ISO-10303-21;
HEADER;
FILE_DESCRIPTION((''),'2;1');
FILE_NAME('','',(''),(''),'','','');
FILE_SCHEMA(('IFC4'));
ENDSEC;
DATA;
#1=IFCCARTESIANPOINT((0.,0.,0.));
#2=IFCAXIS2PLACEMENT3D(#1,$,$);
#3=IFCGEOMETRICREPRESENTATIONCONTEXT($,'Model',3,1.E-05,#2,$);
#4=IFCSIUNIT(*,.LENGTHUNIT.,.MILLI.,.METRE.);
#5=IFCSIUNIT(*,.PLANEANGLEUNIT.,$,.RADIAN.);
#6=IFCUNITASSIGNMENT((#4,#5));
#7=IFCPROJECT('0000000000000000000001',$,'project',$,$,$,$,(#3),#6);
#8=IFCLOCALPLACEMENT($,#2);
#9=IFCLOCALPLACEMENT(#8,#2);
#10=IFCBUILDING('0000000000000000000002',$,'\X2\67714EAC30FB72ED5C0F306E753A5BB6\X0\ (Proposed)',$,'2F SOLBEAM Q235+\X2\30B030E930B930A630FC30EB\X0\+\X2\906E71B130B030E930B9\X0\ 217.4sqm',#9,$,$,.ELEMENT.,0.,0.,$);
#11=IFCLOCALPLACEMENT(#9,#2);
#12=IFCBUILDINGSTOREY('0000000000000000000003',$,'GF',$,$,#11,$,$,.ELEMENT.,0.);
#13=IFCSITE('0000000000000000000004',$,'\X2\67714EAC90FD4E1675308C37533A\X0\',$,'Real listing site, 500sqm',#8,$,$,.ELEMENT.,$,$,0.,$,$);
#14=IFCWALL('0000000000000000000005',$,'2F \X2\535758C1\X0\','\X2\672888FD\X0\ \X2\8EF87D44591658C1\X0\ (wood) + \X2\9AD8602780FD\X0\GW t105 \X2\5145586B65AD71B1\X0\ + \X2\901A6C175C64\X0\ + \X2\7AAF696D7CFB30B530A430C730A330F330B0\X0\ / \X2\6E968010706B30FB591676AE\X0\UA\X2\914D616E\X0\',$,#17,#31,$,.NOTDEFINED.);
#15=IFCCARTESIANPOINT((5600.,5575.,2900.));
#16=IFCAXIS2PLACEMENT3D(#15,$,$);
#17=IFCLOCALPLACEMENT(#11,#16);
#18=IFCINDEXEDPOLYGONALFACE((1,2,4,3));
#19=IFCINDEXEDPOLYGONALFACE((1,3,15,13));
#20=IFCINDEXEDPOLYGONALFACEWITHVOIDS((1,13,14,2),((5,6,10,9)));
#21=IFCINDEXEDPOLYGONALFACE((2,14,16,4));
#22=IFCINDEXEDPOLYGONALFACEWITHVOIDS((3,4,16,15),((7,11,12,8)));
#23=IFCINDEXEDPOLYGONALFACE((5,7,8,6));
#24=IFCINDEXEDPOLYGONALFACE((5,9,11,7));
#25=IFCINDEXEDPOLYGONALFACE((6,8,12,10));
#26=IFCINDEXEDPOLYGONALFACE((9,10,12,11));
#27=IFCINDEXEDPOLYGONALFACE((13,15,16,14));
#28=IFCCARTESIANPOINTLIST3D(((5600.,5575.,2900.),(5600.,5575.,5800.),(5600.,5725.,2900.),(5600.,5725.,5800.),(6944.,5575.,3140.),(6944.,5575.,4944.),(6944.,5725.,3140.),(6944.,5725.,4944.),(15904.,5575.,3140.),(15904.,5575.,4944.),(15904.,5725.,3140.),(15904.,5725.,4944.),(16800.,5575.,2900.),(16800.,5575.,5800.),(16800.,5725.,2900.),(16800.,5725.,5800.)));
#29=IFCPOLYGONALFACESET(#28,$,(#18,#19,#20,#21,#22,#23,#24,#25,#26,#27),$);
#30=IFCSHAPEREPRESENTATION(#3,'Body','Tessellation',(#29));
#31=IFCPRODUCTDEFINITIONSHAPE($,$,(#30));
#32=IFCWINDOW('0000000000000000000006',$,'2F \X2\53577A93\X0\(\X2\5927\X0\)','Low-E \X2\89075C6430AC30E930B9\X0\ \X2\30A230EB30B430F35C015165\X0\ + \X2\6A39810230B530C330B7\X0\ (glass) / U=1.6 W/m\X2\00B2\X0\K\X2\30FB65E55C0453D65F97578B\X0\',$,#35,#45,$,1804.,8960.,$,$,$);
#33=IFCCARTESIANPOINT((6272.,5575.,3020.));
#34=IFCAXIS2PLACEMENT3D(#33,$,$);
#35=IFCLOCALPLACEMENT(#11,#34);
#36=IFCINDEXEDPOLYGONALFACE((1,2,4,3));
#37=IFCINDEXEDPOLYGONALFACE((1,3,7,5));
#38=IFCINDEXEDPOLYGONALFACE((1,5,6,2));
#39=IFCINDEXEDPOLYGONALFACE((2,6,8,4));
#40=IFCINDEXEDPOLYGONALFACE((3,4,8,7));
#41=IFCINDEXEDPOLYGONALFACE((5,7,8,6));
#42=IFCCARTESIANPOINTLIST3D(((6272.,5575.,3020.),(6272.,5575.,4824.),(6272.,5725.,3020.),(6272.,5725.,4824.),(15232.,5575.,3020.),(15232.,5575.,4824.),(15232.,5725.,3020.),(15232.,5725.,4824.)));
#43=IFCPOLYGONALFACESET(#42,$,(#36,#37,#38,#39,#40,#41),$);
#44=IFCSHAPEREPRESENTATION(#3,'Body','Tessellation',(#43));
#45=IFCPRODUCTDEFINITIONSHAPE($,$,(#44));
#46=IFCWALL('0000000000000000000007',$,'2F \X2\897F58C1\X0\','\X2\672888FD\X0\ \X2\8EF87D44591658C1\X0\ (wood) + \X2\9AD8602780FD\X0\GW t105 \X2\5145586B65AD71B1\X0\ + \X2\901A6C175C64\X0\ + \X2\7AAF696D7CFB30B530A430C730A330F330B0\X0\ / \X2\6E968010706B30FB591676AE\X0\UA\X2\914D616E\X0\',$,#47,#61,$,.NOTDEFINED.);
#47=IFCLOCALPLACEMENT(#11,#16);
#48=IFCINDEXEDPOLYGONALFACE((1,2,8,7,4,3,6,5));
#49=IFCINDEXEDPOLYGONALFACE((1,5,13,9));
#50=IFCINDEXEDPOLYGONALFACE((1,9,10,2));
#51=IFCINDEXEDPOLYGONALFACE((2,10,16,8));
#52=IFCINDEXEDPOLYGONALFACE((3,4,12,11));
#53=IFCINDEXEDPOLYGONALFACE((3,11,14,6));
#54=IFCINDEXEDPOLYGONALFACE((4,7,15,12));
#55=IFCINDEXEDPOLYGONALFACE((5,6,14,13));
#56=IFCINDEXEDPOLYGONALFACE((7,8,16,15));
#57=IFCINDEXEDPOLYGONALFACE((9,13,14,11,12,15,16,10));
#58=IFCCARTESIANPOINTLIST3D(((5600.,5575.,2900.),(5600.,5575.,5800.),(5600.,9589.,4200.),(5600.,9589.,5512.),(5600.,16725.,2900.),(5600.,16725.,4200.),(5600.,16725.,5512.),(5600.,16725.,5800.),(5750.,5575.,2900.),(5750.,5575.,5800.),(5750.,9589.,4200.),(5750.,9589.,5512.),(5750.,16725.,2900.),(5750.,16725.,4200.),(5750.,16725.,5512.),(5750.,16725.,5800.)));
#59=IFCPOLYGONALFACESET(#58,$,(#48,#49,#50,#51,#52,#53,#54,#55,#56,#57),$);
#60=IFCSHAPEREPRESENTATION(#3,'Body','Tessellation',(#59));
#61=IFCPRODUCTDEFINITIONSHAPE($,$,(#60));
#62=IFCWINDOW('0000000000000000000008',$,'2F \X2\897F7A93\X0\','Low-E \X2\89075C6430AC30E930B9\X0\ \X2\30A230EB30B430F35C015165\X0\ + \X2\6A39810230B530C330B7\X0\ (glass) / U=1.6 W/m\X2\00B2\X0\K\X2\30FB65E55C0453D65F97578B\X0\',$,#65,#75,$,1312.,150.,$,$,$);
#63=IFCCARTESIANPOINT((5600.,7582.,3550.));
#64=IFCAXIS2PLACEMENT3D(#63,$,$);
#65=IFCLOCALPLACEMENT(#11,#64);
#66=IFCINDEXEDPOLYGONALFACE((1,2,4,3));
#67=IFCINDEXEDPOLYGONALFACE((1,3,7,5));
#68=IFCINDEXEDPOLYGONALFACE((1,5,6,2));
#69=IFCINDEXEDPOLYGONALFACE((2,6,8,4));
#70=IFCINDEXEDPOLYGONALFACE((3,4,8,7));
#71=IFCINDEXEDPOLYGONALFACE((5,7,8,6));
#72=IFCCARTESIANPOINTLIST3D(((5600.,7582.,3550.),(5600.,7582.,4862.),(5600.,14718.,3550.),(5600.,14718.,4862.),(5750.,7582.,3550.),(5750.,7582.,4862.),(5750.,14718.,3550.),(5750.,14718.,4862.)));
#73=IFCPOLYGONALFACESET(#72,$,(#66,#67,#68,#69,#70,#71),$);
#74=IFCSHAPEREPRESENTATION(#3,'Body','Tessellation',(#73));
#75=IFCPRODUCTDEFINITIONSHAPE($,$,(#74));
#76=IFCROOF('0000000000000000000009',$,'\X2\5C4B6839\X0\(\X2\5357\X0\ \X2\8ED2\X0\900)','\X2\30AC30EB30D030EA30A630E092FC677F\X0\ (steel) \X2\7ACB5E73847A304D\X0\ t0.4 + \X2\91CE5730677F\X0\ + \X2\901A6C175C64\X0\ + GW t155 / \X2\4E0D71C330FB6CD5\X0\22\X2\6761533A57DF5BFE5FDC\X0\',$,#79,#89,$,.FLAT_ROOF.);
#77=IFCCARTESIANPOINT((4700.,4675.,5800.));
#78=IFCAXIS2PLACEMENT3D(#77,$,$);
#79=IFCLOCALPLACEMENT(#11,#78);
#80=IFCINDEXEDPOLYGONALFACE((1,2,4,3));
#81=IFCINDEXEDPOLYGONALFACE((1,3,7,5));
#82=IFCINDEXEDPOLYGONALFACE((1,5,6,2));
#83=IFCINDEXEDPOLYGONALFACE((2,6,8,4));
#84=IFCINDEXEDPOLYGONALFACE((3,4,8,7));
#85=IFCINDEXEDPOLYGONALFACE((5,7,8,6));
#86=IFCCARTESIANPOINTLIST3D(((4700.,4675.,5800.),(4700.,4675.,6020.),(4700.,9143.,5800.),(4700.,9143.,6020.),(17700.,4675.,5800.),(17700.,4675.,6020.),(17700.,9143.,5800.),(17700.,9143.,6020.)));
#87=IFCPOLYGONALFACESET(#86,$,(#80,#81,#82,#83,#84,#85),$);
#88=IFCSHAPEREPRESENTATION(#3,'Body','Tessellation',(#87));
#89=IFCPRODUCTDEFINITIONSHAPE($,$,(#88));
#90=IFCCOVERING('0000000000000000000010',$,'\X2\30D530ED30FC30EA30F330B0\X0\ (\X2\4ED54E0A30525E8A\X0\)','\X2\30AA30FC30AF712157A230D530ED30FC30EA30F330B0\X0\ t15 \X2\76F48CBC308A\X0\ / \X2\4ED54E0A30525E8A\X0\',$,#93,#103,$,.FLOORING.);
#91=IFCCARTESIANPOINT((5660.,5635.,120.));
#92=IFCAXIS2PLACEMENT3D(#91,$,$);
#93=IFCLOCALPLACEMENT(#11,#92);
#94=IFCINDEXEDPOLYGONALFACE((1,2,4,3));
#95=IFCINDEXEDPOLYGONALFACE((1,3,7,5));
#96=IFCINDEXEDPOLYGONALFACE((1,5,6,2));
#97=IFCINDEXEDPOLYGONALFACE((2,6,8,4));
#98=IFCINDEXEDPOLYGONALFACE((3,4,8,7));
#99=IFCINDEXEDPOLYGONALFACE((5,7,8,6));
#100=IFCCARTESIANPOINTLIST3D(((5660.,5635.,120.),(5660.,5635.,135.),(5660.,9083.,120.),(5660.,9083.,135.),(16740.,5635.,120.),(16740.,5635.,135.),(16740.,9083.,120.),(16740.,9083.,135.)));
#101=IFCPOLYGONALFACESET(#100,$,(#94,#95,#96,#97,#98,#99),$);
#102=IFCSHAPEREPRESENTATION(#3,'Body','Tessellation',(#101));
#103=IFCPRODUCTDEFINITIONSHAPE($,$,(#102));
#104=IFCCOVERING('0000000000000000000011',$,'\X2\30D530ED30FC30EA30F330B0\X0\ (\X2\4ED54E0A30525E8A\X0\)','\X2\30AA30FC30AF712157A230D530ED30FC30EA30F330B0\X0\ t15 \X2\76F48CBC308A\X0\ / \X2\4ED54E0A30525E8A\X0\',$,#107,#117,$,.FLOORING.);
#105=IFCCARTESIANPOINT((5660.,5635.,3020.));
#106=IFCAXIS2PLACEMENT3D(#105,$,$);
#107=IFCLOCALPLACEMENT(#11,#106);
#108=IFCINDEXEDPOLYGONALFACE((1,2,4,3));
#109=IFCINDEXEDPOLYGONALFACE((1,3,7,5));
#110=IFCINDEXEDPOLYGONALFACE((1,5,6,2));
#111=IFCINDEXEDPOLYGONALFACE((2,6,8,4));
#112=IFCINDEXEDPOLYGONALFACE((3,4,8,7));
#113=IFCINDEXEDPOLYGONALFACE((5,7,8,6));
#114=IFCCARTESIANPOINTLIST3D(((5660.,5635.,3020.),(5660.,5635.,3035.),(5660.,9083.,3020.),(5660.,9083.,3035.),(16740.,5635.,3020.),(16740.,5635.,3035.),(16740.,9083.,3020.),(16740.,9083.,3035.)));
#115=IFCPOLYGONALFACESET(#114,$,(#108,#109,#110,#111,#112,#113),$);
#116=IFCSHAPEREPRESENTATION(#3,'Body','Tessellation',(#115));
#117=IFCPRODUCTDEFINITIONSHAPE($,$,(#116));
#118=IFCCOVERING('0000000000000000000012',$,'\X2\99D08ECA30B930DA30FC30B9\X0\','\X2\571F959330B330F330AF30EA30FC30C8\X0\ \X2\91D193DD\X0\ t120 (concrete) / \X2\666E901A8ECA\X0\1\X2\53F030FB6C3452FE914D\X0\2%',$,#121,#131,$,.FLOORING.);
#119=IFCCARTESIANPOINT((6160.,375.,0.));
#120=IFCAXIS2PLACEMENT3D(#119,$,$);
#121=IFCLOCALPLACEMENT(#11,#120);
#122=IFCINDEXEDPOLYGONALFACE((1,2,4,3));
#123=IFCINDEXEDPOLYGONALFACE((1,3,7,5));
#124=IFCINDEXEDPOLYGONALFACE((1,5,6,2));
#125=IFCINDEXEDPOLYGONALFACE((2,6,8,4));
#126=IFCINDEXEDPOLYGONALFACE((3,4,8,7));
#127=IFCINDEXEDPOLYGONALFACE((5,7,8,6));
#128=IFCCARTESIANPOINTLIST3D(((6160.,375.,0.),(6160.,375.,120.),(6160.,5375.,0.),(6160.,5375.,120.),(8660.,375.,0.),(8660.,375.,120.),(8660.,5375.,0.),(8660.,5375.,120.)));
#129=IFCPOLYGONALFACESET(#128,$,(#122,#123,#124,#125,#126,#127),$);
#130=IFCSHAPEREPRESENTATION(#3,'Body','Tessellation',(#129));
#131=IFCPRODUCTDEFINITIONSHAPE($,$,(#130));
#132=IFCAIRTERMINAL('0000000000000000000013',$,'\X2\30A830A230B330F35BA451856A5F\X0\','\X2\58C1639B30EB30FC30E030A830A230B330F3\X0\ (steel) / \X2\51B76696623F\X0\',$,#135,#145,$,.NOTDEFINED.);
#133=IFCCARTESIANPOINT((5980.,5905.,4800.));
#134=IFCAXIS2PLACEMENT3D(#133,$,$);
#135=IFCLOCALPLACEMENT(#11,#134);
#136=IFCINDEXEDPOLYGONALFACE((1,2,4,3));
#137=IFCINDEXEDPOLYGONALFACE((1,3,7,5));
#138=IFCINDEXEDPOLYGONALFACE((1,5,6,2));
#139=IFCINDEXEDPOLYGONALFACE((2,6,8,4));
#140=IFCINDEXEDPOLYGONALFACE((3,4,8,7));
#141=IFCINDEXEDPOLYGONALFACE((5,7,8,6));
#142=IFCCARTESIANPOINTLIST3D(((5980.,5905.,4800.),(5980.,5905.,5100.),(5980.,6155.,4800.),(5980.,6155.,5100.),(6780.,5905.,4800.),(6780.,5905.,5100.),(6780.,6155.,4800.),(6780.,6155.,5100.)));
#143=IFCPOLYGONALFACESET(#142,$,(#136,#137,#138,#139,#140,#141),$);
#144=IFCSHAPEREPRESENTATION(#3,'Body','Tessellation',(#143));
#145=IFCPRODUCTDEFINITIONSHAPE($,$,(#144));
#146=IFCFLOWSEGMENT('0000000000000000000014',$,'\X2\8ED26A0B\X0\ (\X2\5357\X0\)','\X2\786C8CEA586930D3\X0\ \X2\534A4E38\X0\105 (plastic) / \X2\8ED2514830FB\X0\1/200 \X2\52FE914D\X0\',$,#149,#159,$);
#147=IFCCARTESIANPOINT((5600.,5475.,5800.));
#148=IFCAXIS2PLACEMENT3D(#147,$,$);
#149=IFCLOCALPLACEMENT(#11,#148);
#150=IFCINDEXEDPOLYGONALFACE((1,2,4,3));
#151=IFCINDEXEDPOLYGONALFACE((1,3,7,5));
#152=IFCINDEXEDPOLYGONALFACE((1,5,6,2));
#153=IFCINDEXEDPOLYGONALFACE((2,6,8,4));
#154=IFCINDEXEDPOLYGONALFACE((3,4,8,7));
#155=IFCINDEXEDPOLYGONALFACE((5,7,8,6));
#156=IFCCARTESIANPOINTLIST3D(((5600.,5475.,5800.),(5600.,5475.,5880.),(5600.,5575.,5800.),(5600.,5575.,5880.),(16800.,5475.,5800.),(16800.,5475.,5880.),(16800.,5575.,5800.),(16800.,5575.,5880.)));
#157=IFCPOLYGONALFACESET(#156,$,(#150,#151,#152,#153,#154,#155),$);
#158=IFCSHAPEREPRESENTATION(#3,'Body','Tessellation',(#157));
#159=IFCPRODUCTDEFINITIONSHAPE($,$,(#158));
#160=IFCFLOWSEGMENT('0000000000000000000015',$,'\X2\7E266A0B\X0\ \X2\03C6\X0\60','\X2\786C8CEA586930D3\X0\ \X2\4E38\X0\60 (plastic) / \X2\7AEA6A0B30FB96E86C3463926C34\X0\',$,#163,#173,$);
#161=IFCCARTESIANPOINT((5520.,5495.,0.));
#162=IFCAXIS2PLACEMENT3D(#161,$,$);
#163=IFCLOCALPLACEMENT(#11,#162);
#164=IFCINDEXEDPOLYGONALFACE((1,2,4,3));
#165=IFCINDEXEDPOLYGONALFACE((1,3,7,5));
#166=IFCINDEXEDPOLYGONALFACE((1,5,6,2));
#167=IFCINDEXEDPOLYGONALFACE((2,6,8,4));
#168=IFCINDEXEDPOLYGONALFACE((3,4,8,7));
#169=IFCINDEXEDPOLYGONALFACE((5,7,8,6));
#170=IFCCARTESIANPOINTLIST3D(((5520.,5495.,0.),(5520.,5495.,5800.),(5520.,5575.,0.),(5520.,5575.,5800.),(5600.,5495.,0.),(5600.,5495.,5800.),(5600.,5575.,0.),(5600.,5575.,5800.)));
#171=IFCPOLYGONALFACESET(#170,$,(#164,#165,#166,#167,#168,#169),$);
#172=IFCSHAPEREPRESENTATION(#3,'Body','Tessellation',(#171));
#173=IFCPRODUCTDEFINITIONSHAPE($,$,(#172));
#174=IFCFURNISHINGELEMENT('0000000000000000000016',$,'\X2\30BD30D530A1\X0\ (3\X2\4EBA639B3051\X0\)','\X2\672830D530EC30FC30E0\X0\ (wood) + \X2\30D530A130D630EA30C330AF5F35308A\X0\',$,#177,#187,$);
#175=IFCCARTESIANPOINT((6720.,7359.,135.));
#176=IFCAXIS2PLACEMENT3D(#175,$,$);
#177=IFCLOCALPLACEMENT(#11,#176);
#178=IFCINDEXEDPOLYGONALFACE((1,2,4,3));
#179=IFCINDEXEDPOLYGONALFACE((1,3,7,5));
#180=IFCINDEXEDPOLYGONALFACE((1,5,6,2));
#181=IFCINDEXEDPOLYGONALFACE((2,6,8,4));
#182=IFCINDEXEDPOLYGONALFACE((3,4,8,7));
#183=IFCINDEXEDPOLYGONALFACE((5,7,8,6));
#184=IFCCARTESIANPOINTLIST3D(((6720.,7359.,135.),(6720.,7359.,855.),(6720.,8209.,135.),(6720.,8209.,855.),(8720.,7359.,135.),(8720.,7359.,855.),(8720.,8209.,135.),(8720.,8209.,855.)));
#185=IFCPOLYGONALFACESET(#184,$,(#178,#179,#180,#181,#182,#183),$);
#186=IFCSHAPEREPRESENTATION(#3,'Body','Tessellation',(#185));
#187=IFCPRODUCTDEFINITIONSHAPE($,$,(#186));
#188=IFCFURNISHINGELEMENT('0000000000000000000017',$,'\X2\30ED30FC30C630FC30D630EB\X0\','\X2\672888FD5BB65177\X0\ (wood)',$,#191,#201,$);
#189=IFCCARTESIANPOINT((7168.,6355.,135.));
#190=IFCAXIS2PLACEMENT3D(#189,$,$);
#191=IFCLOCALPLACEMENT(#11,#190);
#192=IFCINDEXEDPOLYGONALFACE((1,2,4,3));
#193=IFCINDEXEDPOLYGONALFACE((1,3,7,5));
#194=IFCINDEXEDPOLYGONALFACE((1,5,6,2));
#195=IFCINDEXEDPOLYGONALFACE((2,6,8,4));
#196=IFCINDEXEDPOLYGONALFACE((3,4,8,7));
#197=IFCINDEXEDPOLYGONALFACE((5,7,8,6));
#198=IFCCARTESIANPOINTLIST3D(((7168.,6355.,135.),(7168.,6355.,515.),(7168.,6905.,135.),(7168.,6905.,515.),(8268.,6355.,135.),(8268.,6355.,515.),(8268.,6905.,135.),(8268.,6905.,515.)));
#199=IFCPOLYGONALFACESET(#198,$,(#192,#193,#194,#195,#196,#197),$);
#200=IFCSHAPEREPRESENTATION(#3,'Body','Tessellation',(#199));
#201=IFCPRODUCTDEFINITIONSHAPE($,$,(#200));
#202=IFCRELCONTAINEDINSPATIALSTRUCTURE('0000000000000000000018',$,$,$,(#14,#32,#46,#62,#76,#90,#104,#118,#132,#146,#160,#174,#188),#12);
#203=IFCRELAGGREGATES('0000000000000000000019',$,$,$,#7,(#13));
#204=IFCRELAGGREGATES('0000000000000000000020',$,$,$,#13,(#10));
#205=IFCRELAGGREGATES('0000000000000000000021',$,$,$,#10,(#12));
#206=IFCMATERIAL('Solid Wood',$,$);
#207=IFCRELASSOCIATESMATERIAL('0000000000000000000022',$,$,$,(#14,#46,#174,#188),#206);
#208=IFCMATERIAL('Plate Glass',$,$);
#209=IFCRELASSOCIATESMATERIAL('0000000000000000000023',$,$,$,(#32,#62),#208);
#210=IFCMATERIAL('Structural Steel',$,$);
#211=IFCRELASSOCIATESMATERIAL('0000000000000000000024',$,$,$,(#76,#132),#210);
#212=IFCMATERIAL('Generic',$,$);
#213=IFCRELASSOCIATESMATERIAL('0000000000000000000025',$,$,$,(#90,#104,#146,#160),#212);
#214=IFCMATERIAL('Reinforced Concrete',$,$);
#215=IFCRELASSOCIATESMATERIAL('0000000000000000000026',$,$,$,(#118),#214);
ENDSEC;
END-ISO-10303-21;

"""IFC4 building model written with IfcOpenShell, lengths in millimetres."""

from ifc_helpers import new_model, si_unit, frame, frame_2d, origin, place, context, project, spatial, rectangle, extrude, material, element, fill, save


model = new_model("IFC4")

# Units and contexts
model_context = context("Model", 3, precision=1e-05, world=origin())
ifc_project = project(units=[si_unit("LENGTHUNIT", "METRE", prefix="MILLI"), si_unit("PLANEANGLEUNIT", "RADIAN")], contexts=[model_context])

# Site, building, storey
site_placement = place(None, origin())
site = spatial("IfcSite", under=ifc_project, at=site_placement, Name="東京都世田谷区", ObjectType="Real listing site, 500sqm", CompositionType="ELEMENT", RefElevation=0.0)
building_placement = place(site_placement, origin())
building = spatial("IfcBuilding", under=site, at=building_placement, Name="東京・狭小の町家 (Proposed)", ObjectType="2F SOLBEAM Q235+グラスウール+遮熱グラス 217.4sqm", CompositionType="ELEMENT", ElevationOfRefHeight=0.0, ElevationOfTerrain=0.0)
storey_placement = place(building_placement, origin())
storey = spatial("IfcBuildingStorey", under=building, at=storey_placement, Name="GF", CompositionType="ELEMENT", Elevation=0.0)

# Shared definitions
ifc_material_1 = material(Name="Solid Wood")

# Shared definitions
ifc_material_2 = material(Name="Reinforced Concrete")

# Shared definitions
ifc_material_3 = material(Name="Plate Glass")

# Walls, openings, windows
wall_1_placement = place(storey_placement, frame((5600.0, 5575.0, 2900.0)))
wall_1 = element("IfcWall", 1, at=wall_1_placement, inside=storey, material=ifc_material_1, Name="2F 南壁", Description="木製 軸組外壁 (wood) + 高性能GW t105 充填断熱 + 通気層 + 窯業系サイディング / 準耐火・外皮UA配慮", PredefinedType="NOTDEFINED", context=model_context, shape_type="SweptSolid", body=[
    extrude(rectangle(XDim=11200.0, YDim=150.0, at=frame_2d((5600.0, 75.0))), frame((5600.0, 5575.0, 2900.0)), (0.0, 0.0, 1.0), 2900.0),
])
opening_1_placement = place(storey_placement, frame((6272.0, 5575.0, 3020.0)))
opening_1 = element("IfcOpeningElement", 2, at=opening_1_placement, cuts=wall_1, PredefinedType="NOTDEFINED", context=model_context, shape_type="SweptSolid", body=[
    extrude(rectangle(XDim=8960.0, YDim=150.0, at=frame_2d((4480.0, 75.0))), frame((6272.0, 5575.0, 3020.0)), (0.0, 0.0, 1.0), 1804.0),
])
window_1_placement = place(storey_placement, frame((6272.0, 5575.0, 3020.0)))
window_1 = element("IfcWindow", 3, at=window_1_placement, inside=storey, material=ifc_material_3, Name="2F 南窓(大)", Description="Low-E 複層ガラス アルゴン封入 + 樹脂サッシ (glass) / U=1.6 W/m²K・日射取得型", OverallHeight=1804.0, OverallWidth=8960.0, context=model_context, shape_type="SweptSolid", body=[
    extrude(rectangle(XDim=8960.0, YDim=150.0, at=frame_2d((4480.0, 75.0))), frame((6272.0, 5575.0, 3020.0)), (0.0, 0.0, 1.0), 1804.0),
])
fill(opening_1, window_1)
wall_2_placement = place(storey_placement, frame((5600.0, 5575.0, 2900.0)))
wall_2 = element("IfcWall", 4, at=wall_2_placement, inside=storey, material=ifc_material_1, Name="2F 西壁", Description="木製 軸組外壁 (wood) + 高性能GW t105 充填断熱 + 通気層 + 窯業系サイディング / 準耐火・外皮UA配慮", PredefinedType="NOTDEFINED", context=model_context, shape_type="SweptSolid", body=[
    extrude(rectangle(XDim=150.0, YDim=11150.0, at=frame_2d((75.0, 5575.0))), frame((5600.0, 5575.0, 2900.0)), (0.0, 0.0, 1.0), 2900.0),
])
opening_2_placement = place(storey_placement, frame((5600.0, 7582.0, 3550.0)))
opening_2 = element("IfcOpeningElement", 5, at=opening_2_placement, cuts=wall_2, PredefinedType="NOTDEFINED", context=model_context, shape_type="SweptSolid", body=[
    extrude(rectangle(XDim=150.0, YDim=7136.0, at=frame_2d((75.0, 3568.0))), frame((5600.0, 7582.0, 3550.0)), (0.0, 0.0, 1.0), 1312.0),
])
window_2_placement = place(storey_placement, frame((5600.0, 7582.0, 3550.0)))
window_2 = element("IfcWindow", 6, at=window_2_placement, inside=storey, material=ifc_material_3, Name="2F 西窓", Description="Low-E 複層ガラス アルゴン封入 + 樹脂サッシ (glass) / U=1.6 W/m²K・日射取得型", OverallHeight=1312.0, OverallWidth=150.0, context=model_context, shape_type="SweptSolid", body=[
    extrude(rectangle(XDim=150.0, YDim=7136.0, at=frame_2d((75.0, 3568.0))), frame((5600.0, 7582.0, 3550.0)), (0.0, 0.0, 1.0), 1312.0),
])
fill(opening_2, window_2)

# Roof
ifc_material_4 = material(Name="Structural Steel")
for number, where, name in (
    (7, (4700.0, 4675.0, 5800.0), "屋根(南 軒900)"),
):
    element("IfcRoof", number, at=place(storey_placement, frame(where)), inside=storey, material=ifc_material_4, Name=name, Description="ガルバリウム鋼板 (steel) 立平葺き t0.4 + 野地板 + 通気層 + GW t155 / 不燃・法22条区域対応", PredefinedType="FLAT_ROOF", context=model_context, shape_type="SweptSolid", body=[
        extrude(rectangle(XDim=13000.0, YDim=4468.0, at=frame_2d((6500.0, 2234.0))), frame((4700.0, 4675.0, 5800.0)), (0.0, 0.0, 1.0), 220.0),
    ])

# Coverings
ifc_material_5 = material(Name="Generic")
covering_1_placement = place(storey_placement, frame((5660.0, 5635.0, 120.0)))
element("IfcCovering", 8, at=covering_1_placement, inside=storey, material=ifc_material_5, Name="フローリング (仕上げ床)", Description="オーク無垢フローリング t15 直貼り / 仕上げ床", PredefinedType="FLOORING", context=model_context, shape_type="SweptSolid", body=[
    extrude(rectangle(XDim=11080.0, YDim=3448.0, at=frame_2d((5540.0, 1724.0))), frame((5660.0, 5635.0, 120.0)), (0.0, 0.0, 1.0), 15.0),
])
covering_2_placement = place(storey_placement, frame((5660.0, 5635.0, 3020.0)))
element("IfcCovering", 9, at=covering_2_placement, inside=storey, material=ifc_material_5, Name="フローリング (仕上げ床)", Description="オーク無垢フローリング t15 直貼り / 仕上げ床", PredefinedType="FLOORING", context=model_context, shape_type="SweptSolid", body=[
    extrude(rectangle(XDim=11080.0, YDim=3448.0, at=frame_2d((5540.0, 1724.0))), frame((5660.0, 5635.0, 3020.0)), (0.0, 0.0, 1.0), 15.0),
])
covering_3_placement = place(storey_placement, frame((6160.0, 375.0, 0.0)))
element("IfcCovering", 10, at=covering_3_placement, inside=storey, material=ifc_material_2, Name="駐車スペース", Description="土間コンクリート 金鏝 t120 (concrete) / 普通車1台・水勾配2%", PredefinedType="FLOORING", context=model_context, shape_type="SweptSolid", body=[
    extrude(rectangle(XDim=2500.0, YDim=5000.0, at=frame_2d((1250.0, 2500.0))), frame((6160.0, 375.0, 0.0)), (0.0, 0.0, 1.0), 120.0),
])

# Air terminal
air_terminal_placement = place(storey_placement, frame((5980.0, 5905.0, 4800.0)))
element("IfcAirTerminal", 11, at=air_terminal_placement, inside=storey, material=ifc_material_4, Name="エアコン室内機", Description="壁掛ルームエアコン (steel) / 冷暖房", PredefinedType="NOTDEFINED", context=model_context, shape_type="SweptSolid", body=[
    extrude(rectangle(XDim=800.0, YDim=250.0, at=frame_2d((400.0, 125.0))), frame((5980.0, 5905.0, 4800.0)), (0.0, 0.0, 1.0), 300.0),
])

# Flow segments
flow_segment_1_placement = place(storey_placement, frame((5600.0, 5475.0, 5800.0)))
element("IfcFlowSegment", 12, at=flow_segment_1_placement, inside=storey, material=ifc_material_5, Name="軒樋 (南)", Description="硬質塩ビ 半丸105 (plastic) / 軒先・1/200 勾配", context=model_context, shape_type="SweptSolid", body=[
    extrude(rectangle(XDim=11200.0, YDim=100.0, at=frame_2d((5600.0, 50.0))), frame((5600.0, 5475.0, 5800.0)), (0.0, 0.0, 1.0), 80.0),
])
flow_segment_2_placement = place(storey_placement, frame((5520.0, 5495.0, 0.0)))
element("IfcFlowSegment", 13, at=flow_segment_2_placement, inside=storey, material=ifc_material_5, Name="縦樋 φ60", Description="硬質塩ビ 丸60 (plastic) / 竪樋・雨水排水", context=model_context, shape_type="SweptSolid", body=[
    extrude(rectangle(XDim=80.0, YDim=80.0, at=frame_2d((40.0, 40.0))), frame((5520.0, 5495.0, 0.0)), (0.0, 0.0, 1.0), 5800.0),
])

# Furnishing elements
furnishing_1_placement = place(storey_placement, frame((6720.0, 7359.0, 135.0)))
element("IfcFurnishingElement", 14, at=furnishing_1_placement, inside=storey, material=ifc_material_1, Name="ソファ (3人掛け)", Description="木フレーム (wood) + ファブリック張り", context=model_context, shape_type="SweptSolid", body=[
    extrude(rectangle(XDim=2000.0, YDim=850.0, at=frame_2d((1000.0, 425.0))), frame((6720.0, 7359.0, 135.0)), (0.0, 0.0, 1.0), 720.0),
])
furnishing_2_placement = place(storey_placement, frame((7168.0, 6355.0, 135.0)))
element("IfcFurnishingElement", 15, at=furnishing_2_placement, inside=storey, material=ifc_material_1, Name="ローテーブル", Description="木製家具 (wood)", context=model_context, shape_type="SweptSolid", body=[
    extrude(rectangle(XDim=1100.0, YDim=550.0, at=frame_2d((550.0, 275.0))), frame((7168.0, 6355.0, 135.0)), (0.0, 0.0, 1.0), 380.0),
])

save(model, "model.ifc")
